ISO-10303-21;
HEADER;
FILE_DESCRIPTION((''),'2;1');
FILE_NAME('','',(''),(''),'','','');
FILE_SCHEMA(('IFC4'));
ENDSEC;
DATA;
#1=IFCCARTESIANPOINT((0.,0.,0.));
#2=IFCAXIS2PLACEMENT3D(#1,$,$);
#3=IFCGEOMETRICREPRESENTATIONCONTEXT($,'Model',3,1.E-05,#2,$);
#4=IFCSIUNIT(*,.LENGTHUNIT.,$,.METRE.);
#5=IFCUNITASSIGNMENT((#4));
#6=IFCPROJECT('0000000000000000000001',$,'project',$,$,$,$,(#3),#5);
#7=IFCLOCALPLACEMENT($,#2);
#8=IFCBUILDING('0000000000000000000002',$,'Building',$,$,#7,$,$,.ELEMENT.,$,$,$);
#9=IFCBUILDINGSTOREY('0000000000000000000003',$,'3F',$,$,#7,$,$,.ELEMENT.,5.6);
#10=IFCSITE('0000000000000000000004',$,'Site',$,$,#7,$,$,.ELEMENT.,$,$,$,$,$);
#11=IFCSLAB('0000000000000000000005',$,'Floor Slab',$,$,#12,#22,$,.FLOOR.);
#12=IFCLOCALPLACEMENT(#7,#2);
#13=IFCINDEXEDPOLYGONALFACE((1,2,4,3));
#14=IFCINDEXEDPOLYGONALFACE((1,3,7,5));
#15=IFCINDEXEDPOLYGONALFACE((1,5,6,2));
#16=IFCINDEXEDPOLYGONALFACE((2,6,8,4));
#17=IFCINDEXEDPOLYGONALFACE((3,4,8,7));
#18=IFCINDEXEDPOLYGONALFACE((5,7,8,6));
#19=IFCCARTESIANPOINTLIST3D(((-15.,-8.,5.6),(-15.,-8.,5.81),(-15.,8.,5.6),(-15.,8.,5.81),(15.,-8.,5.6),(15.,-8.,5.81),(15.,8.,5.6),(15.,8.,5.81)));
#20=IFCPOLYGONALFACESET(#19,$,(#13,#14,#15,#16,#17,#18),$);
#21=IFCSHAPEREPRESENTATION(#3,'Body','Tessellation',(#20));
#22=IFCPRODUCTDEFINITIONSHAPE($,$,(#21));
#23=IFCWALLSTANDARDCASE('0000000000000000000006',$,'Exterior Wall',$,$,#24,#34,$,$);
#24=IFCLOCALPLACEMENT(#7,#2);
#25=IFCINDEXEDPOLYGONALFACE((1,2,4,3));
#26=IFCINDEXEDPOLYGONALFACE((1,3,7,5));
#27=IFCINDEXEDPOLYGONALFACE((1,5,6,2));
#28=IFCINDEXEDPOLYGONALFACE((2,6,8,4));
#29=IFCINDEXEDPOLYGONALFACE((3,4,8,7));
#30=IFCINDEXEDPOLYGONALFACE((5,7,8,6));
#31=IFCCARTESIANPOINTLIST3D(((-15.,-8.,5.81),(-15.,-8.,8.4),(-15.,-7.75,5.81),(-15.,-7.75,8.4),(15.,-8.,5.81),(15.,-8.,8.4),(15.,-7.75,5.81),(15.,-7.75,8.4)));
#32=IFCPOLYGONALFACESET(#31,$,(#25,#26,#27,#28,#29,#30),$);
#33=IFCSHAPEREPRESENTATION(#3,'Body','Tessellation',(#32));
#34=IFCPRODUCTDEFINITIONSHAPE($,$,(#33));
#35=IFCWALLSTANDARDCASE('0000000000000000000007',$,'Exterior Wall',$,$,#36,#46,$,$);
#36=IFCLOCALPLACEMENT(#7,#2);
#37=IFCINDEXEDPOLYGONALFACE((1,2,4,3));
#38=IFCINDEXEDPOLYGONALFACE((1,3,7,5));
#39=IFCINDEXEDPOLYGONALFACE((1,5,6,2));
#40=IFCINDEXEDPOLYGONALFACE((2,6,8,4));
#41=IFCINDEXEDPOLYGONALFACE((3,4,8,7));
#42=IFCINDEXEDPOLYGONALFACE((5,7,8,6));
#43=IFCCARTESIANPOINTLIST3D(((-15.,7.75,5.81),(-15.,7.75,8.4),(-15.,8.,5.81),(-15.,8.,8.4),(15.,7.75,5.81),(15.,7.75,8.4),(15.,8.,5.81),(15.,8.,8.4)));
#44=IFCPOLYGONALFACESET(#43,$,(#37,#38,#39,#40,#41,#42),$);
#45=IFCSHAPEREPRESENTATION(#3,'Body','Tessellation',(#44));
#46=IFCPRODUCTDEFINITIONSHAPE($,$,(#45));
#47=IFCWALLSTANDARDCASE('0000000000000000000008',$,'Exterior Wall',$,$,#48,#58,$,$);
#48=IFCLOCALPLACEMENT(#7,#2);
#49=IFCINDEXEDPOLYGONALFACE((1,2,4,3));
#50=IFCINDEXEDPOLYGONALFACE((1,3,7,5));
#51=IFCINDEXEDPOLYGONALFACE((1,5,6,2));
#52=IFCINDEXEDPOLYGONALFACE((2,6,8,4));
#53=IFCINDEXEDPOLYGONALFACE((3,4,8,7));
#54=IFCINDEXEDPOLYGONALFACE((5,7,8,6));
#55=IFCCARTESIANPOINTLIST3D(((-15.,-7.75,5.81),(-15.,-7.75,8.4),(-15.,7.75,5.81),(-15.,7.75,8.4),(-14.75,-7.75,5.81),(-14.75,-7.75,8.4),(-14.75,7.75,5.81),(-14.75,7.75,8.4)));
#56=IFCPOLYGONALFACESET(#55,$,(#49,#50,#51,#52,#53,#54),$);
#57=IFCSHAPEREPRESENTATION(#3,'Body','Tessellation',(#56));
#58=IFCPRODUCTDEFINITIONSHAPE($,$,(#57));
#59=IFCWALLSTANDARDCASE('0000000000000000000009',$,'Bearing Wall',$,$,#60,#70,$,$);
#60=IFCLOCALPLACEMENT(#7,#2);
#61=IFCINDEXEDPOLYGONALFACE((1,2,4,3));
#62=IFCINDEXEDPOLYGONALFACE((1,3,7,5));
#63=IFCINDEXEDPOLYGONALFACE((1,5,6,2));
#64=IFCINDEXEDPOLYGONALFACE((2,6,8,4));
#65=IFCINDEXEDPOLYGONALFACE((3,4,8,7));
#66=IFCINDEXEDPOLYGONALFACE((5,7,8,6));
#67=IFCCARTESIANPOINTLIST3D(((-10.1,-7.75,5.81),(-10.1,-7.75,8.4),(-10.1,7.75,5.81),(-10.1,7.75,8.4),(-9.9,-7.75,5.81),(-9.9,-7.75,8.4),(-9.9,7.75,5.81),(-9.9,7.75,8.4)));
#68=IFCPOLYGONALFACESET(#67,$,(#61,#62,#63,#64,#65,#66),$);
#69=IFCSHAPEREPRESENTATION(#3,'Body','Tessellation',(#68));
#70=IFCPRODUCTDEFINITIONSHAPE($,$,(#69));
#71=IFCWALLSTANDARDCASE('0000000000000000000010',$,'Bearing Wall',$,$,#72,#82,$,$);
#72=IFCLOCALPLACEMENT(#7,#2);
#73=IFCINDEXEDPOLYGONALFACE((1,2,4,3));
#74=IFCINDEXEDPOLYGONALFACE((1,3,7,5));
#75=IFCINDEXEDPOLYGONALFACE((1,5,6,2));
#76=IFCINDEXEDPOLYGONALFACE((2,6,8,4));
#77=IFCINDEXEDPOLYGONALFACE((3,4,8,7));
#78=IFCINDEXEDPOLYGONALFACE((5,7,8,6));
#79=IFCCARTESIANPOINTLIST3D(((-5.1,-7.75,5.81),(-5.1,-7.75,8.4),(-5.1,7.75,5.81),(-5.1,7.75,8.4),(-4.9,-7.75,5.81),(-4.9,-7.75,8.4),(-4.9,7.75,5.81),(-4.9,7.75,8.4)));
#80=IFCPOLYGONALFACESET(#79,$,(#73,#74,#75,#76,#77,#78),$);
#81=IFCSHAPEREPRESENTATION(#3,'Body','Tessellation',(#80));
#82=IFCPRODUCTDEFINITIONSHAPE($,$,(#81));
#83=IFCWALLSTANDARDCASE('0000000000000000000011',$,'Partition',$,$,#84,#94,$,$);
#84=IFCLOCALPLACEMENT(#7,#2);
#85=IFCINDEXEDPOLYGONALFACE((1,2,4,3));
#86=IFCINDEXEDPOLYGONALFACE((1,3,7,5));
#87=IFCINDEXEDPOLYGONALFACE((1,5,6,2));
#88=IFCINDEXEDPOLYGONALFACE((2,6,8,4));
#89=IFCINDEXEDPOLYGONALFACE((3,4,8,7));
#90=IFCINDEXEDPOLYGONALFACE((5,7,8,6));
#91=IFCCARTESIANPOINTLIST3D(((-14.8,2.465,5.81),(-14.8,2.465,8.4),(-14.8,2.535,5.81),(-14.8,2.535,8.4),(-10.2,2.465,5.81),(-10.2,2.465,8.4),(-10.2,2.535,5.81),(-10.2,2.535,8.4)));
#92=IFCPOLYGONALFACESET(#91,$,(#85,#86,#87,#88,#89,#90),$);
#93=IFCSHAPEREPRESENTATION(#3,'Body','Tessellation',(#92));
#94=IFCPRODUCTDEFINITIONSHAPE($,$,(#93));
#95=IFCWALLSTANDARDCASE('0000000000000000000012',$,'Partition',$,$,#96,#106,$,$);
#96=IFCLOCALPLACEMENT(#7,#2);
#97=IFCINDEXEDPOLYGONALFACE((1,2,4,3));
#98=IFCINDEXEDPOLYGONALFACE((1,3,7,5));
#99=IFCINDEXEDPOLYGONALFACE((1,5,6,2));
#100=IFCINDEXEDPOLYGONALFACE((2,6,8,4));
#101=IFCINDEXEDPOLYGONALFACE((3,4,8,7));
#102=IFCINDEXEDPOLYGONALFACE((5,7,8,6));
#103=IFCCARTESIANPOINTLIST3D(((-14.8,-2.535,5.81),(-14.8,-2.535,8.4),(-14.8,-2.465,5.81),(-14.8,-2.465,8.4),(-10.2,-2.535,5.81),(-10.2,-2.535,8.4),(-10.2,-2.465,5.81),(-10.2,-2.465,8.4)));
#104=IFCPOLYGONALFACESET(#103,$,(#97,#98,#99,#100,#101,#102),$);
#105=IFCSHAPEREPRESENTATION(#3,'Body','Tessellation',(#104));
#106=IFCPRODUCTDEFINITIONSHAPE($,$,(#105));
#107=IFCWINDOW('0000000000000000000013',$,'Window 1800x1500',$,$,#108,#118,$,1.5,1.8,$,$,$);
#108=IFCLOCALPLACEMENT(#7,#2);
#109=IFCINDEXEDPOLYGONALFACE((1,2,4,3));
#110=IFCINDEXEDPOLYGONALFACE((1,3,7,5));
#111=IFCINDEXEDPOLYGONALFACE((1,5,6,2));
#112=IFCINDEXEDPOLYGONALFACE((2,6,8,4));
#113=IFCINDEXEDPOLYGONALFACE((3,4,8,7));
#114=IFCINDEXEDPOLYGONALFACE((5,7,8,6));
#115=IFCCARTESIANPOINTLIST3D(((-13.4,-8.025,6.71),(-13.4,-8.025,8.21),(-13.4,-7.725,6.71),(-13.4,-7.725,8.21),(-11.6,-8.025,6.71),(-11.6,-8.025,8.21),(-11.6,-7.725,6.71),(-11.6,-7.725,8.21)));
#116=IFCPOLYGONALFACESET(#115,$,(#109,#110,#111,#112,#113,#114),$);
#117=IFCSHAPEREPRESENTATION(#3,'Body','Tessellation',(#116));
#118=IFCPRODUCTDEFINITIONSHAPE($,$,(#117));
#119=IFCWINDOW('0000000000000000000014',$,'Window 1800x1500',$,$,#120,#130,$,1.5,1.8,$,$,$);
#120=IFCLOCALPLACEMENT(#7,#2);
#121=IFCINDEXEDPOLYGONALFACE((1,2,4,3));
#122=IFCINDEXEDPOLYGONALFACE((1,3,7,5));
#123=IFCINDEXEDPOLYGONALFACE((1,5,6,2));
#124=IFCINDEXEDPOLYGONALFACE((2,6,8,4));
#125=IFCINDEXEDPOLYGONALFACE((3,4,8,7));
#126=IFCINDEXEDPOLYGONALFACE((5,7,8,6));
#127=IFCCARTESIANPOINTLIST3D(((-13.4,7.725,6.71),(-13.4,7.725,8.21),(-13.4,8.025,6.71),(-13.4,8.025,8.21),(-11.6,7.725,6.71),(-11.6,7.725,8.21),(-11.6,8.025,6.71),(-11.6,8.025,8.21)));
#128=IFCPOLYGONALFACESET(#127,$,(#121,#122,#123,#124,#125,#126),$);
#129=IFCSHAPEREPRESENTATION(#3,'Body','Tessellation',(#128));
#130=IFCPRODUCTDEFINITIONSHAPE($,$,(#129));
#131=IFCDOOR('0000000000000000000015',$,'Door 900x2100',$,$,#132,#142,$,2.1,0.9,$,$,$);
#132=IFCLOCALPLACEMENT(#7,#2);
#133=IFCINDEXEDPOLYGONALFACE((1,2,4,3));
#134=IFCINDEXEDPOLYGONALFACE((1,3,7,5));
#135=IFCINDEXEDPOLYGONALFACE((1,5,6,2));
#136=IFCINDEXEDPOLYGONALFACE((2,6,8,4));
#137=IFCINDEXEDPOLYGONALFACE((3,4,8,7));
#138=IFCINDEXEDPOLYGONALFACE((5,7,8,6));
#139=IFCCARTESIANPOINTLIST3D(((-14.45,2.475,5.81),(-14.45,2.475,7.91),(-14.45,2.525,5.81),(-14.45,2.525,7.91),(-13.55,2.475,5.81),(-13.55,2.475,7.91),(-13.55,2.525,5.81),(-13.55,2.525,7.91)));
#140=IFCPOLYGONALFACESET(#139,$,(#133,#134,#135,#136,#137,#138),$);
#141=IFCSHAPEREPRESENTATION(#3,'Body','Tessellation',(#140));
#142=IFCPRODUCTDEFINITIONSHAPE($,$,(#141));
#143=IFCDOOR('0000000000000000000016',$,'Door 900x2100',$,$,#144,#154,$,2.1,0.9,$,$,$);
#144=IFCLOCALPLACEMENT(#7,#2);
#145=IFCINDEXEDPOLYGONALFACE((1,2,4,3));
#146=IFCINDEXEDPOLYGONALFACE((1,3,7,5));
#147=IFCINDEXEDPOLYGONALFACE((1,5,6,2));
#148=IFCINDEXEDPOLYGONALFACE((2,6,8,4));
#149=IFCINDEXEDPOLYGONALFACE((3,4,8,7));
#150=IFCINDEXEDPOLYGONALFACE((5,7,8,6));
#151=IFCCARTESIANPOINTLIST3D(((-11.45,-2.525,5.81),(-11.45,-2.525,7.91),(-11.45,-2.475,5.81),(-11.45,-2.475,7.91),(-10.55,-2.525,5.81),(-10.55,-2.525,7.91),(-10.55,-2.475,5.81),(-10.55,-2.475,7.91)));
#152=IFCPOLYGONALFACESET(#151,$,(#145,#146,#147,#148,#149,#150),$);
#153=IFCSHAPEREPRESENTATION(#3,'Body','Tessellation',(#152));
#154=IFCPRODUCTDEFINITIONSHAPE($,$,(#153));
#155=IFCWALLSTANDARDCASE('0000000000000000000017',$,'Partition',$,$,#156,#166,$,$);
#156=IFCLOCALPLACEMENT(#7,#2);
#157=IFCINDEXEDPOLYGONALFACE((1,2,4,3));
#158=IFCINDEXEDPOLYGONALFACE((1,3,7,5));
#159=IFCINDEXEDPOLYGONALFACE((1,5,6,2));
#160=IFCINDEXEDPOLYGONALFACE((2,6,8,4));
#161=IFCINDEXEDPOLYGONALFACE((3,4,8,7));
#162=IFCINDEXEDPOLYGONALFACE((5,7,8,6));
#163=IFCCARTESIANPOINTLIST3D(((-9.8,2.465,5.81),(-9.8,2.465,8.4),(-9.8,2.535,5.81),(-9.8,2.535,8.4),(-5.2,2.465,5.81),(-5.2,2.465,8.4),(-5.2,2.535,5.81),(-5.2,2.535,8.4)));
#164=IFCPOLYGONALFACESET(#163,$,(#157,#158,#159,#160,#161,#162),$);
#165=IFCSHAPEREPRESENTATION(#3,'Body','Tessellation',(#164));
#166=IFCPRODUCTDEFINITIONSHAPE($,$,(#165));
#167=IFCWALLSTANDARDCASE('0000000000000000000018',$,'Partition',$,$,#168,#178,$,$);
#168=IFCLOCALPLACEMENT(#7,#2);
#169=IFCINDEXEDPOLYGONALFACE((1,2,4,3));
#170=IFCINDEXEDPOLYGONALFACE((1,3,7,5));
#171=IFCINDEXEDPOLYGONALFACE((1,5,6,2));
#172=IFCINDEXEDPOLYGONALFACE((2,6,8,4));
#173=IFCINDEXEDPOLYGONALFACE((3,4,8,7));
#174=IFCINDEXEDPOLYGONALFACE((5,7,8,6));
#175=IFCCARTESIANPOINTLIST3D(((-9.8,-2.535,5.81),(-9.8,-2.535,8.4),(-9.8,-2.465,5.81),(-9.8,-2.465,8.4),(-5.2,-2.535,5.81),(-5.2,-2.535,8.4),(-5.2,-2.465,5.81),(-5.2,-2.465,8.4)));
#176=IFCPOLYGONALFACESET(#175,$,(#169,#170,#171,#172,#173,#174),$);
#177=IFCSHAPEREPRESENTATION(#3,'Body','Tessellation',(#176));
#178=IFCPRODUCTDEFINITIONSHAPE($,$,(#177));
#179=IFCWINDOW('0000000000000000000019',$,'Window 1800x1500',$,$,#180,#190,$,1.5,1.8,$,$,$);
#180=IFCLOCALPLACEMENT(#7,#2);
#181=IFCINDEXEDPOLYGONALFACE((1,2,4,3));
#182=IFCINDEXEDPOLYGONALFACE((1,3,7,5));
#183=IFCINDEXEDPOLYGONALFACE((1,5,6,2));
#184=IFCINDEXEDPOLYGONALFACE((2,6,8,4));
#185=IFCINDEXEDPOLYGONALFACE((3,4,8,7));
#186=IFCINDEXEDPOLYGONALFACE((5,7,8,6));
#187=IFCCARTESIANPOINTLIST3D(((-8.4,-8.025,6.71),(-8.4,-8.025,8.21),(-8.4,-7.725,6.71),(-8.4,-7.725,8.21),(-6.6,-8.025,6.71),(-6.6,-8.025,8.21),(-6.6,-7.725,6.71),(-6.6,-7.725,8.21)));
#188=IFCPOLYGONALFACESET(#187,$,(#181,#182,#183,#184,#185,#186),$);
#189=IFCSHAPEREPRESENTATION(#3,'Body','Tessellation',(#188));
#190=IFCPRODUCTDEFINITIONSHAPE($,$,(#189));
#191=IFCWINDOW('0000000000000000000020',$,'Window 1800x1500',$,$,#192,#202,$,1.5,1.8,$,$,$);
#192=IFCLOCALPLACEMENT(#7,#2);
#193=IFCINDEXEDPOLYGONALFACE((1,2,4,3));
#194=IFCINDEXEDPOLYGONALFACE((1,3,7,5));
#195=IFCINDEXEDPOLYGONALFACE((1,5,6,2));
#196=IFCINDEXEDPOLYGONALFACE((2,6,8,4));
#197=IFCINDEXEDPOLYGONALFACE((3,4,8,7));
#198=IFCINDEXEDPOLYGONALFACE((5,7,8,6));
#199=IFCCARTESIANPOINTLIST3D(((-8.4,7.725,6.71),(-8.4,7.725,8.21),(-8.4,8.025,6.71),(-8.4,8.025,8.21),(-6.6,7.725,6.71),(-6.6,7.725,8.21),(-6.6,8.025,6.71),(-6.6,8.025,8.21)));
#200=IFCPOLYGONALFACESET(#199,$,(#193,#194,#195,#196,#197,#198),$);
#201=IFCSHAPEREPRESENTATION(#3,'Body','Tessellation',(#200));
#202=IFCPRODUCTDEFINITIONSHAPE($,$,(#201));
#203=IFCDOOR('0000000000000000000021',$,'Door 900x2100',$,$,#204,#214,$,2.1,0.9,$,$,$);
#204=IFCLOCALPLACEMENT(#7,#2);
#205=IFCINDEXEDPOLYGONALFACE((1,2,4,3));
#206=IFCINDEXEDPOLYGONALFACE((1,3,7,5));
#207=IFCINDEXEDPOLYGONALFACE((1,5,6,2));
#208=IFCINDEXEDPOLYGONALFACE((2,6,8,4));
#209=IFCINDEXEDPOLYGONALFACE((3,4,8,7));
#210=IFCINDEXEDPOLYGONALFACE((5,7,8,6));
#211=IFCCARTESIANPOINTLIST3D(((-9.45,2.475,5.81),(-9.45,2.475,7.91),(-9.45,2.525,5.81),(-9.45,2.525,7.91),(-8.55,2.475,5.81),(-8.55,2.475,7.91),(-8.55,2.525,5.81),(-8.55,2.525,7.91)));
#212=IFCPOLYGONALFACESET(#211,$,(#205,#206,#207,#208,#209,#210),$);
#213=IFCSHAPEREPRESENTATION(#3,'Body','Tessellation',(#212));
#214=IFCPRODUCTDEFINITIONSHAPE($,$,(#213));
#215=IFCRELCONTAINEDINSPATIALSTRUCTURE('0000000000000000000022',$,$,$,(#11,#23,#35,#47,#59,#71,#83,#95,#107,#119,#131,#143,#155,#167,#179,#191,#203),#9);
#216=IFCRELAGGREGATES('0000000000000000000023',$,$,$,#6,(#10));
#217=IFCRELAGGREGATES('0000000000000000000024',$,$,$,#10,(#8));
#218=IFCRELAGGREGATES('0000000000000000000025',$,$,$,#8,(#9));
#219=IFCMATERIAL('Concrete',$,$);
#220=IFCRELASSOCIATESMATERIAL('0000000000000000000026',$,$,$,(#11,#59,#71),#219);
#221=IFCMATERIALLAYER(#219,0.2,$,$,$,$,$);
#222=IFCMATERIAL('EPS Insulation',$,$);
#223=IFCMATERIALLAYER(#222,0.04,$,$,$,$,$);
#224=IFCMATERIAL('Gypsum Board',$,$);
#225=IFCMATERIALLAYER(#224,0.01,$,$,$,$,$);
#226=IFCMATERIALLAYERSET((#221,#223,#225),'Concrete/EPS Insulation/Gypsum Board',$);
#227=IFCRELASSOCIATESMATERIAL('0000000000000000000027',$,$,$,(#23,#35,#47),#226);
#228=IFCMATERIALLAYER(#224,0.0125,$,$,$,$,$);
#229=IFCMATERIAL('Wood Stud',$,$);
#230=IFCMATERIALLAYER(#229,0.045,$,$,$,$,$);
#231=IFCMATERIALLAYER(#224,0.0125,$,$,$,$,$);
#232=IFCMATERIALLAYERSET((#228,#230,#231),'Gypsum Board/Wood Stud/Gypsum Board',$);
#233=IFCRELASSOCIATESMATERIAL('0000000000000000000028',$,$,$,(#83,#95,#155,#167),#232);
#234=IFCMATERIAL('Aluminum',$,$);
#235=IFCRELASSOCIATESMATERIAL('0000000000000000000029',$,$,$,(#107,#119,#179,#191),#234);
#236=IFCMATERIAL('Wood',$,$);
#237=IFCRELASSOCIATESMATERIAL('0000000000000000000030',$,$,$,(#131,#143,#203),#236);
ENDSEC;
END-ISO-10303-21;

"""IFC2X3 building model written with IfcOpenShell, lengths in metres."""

from ifc_helpers import new_model, si_unit, frame, origin, origin_2d, place, context, project, spatial, rectangle, extrude, material, layer, layer_set, layer_usage, element, save


model = new_model("IFC2X3")

# Units and contexts
model_context = context("Model", 3, precision=1e-05, world=origin())
ifc_project = project(units=[si_unit("LENGTHUNIT", "METRE")], contexts=[model_context])

# Site, building, storey
placement = place(None, origin())
site = spatial("IfcSite", under=ifc_project, at=placement, Name="Site", CompositionType="ELEMENT")
building = spatial("IfcBuilding", under=site, at=placement, Name="Building", CompositionType="ELEMENT")
storey = spatial("IfcBuildingStorey", under=building, at=placement, Name="3F", CompositionType="ELEMENT", Elevation=5.6)

# Slab
ifc_material_1 = material(Name="Concrete")
slab_placement = place(None, frame((0.0, 0.0, 5.6)))
element("IfcSlab", 1, at=slab_placement, inside=storey, material=ifc_material_1, Name="Floor Slab", PredefinedType="FLOOR", context=model_context, shape_type="SweptSolid", body=[
    extrude(rectangle(XDim=30.0, YDim=16.0, at=origin_2d()), origin(), (0.0, 0.0, 1.0), 0.21),
])

# Walls
ifc_layer_1 = layer(ifc_material_1, 0.2)
ifc_material_2 = material(Name="EPS Insulation")
ifc_layer_2 = layer(ifc_material_2, 0.04)
ifc_material_3 = material(Name="Gypsum Board")
ifc_layer_3 = layer(ifc_material_3, 0.01)
ifc_layer_set_1 = layer_set([ifc_layer_1, ifc_layer_2, ifc_layer_3], Name="Concrete/EPS Insulation/Gypsum Board")
ifc_layer_usage_1 = layer_usage(ifc_layer_set_1, "AXIS2", "POSITIVE", 0.0)
for number, where, name in (
    (2, (0.0, -7.875, 5.81), "Exterior Wall"),
    (3, (0.0, 7.875, 5.81), "Exterior Wall"),
):
    element("IfcWallStandardCase", number, at=place(None, frame(where)), inside=storey, material=ifc_layer_usage_1, Name=name, context=model_context, shape_type="SweptSolid", body=[
        extrude(rectangle(XDim=30.0, YDim=0.25, at=origin_2d()), origin(), (0.0, 0.0, 1.0), 2.59),
    ])
wall_placement = place(None, frame((-14.875, 0.0, 5.81)))
element("IfcWallStandardCase", 4, at=wall_placement, inside=storey, material=ifc_layer_usage_1, Name="Exterior Wall", context=model_context, shape_type="SweptSolid", body=[
    extrude(rectangle(XDim=0.25, YDim=15.5, at=origin_2d()), origin(), (0.0, 0.0, 1.0), 2.59),
])
for number, where, name in (
    (5, (-10.0, 0.0, 5.81), "Bearing Wall"),
    (6, (-5.0, 0.0, 5.81), "Bearing Wall"),
):
    element("IfcWallStandardCase", number, at=place(None, frame(where)), inside=storey, material=ifc_material_1, Name=name, context=model_context, shape_type="SweptSolid", body=[
        extrude(rectangle(XDim=0.2, YDim=15.5, at=origin_2d()), origin(), (0.0, 0.0, 1.0), 2.59),
    ])
ifc_layer_4 = layer(ifc_material_3, 0.0125)
ifc_material_4 = material(Name="Wood Stud")
ifc_layer_5 = layer(ifc_material_4, 0.045)
ifc_layer_6 = layer(ifc_material_3, 0.0125)
ifc_layer_set_2 = layer_set([ifc_layer_4, ifc_layer_5, ifc_layer_6], Name="Gypsum Board/Wood Stud/Gypsum Board")
ifc_layer_usage_2 = layer_usage(ifc_layer_set_2, "AXIS2", "POSITIVE", 0.0)
for number, where, name in (
    (7, (-12.5, 2.5, 5.81), "Partition"),
    (8, (-12.5, -2.5, 5.81), "Partition"),
):
    element("IfcWallStandardCase", number, at=place(None, frame(where)), inside=storey, material=ifc_layer_usage_2, Name=name, context=model_context, shape_type="SweptSolid", body=[
        extrude(rectangle(XDim=4.6, YDim=0.07, at=origin_2d()), origin(), (0.0, 0.0, 1.0), 2.59),
    ])

# Windows
ifc_material_5 = material(Name="Aluminum")
for number, where, name in (
    (9, (-12.5, -7.875, 6.71), "Window 1800x1500"),
    (10, (-12.5, 7.875, 6.71), "Window 1800x1500"),
):
    element("IfcWindow", number, at=place(None, frame(where)), inside=storey, material=ifc_material_5, Name=name, OverallHeight=1.5, OverallWidth=1.8, context=model_context, shape_type="SweptSolid", body=[
        extrude(rectangle(XDim=1.8, YDim=0.3, at=origin_2d()), origin(), (0.0, 0.0, 1.0), 1.5),
    ])

# Doors
ifc_material_6 = material(Name="Wood")
for number, where, name in (
    (11, (-14.0, 2.5, 5.81), "Door 900x2100"),
    (12, (-11.0, -2.5, 5.81), "Door 900x2100"),
):
    element("IfcDoor", number, at=place(None, frame(where)), inside=storey, material=ifc_material_6, Name=name, OverallHeight=2.1, OverallWidth=0.9, context=model_context, shape_type="SweptSolid", body=[
        extrude(rectangle(XDim=0.9, YDim=0.05, at=origin_2d()), origin(), (0.0, 0.0, 1.0), 2.1),
    ])

# Walls
for number, where, name in (
    (13, (-7.5, 2.5, 5.81), "Partition"),
    (14, (-7.5, -2.5, 5.81), "Partition"),
):
    element("IfcWallStandardCase", number, at=place(None, frame(where)), inside=storey, material=ifc_layer_usage_2, Name=name, context=model_context, shape_type="SweptSolid", body=[
        extrude(rectangle(XDim=4.6, YDim=0.07, at=origin_2d()), origin(), (0.0, 0.0, 1.0), 2.59),
    ])

# Windows
for number, where, name in (
    (15, (-7.5, -7.875, 6.71), "Window 1800x1500"),
    (16, (-7.5, 7.875, 6.71), "Window 1800x1500"),
):
    element("IfcWindow", number, at=place(None, frame(where)), inside=storey, material=ifc_material_5, Name=name, OverallHeight=1.5, OverallWidth=1.8, context=model_context, shape_type="SweptSolid", body=[
        extrude(rectangle(XDim=1.8, YDim=0.3, at=origin_2d()), origin(), (0.0, 0.0, 1.0), 1.5),
    ])

# Door
for number, where, name in (
    (17, (-9.0, 2.5, 5.81), "Door 900x2100"),
):
    element("IfcDoor", number, at=place(None, frame(where)), inside=storey, material=ifc_material_6, Name=name, OverallHeight=2.1, OverallWidth=0.9, context=model_context, shape_type="SweptSolid", body=[
        extrude(rectangle(XDim=0.9, YDim=0.05, at=origin_2d()), origin(), (0.0, 0.0, 1.0), 2.1),
    ])

save(model, "model.ifc")
